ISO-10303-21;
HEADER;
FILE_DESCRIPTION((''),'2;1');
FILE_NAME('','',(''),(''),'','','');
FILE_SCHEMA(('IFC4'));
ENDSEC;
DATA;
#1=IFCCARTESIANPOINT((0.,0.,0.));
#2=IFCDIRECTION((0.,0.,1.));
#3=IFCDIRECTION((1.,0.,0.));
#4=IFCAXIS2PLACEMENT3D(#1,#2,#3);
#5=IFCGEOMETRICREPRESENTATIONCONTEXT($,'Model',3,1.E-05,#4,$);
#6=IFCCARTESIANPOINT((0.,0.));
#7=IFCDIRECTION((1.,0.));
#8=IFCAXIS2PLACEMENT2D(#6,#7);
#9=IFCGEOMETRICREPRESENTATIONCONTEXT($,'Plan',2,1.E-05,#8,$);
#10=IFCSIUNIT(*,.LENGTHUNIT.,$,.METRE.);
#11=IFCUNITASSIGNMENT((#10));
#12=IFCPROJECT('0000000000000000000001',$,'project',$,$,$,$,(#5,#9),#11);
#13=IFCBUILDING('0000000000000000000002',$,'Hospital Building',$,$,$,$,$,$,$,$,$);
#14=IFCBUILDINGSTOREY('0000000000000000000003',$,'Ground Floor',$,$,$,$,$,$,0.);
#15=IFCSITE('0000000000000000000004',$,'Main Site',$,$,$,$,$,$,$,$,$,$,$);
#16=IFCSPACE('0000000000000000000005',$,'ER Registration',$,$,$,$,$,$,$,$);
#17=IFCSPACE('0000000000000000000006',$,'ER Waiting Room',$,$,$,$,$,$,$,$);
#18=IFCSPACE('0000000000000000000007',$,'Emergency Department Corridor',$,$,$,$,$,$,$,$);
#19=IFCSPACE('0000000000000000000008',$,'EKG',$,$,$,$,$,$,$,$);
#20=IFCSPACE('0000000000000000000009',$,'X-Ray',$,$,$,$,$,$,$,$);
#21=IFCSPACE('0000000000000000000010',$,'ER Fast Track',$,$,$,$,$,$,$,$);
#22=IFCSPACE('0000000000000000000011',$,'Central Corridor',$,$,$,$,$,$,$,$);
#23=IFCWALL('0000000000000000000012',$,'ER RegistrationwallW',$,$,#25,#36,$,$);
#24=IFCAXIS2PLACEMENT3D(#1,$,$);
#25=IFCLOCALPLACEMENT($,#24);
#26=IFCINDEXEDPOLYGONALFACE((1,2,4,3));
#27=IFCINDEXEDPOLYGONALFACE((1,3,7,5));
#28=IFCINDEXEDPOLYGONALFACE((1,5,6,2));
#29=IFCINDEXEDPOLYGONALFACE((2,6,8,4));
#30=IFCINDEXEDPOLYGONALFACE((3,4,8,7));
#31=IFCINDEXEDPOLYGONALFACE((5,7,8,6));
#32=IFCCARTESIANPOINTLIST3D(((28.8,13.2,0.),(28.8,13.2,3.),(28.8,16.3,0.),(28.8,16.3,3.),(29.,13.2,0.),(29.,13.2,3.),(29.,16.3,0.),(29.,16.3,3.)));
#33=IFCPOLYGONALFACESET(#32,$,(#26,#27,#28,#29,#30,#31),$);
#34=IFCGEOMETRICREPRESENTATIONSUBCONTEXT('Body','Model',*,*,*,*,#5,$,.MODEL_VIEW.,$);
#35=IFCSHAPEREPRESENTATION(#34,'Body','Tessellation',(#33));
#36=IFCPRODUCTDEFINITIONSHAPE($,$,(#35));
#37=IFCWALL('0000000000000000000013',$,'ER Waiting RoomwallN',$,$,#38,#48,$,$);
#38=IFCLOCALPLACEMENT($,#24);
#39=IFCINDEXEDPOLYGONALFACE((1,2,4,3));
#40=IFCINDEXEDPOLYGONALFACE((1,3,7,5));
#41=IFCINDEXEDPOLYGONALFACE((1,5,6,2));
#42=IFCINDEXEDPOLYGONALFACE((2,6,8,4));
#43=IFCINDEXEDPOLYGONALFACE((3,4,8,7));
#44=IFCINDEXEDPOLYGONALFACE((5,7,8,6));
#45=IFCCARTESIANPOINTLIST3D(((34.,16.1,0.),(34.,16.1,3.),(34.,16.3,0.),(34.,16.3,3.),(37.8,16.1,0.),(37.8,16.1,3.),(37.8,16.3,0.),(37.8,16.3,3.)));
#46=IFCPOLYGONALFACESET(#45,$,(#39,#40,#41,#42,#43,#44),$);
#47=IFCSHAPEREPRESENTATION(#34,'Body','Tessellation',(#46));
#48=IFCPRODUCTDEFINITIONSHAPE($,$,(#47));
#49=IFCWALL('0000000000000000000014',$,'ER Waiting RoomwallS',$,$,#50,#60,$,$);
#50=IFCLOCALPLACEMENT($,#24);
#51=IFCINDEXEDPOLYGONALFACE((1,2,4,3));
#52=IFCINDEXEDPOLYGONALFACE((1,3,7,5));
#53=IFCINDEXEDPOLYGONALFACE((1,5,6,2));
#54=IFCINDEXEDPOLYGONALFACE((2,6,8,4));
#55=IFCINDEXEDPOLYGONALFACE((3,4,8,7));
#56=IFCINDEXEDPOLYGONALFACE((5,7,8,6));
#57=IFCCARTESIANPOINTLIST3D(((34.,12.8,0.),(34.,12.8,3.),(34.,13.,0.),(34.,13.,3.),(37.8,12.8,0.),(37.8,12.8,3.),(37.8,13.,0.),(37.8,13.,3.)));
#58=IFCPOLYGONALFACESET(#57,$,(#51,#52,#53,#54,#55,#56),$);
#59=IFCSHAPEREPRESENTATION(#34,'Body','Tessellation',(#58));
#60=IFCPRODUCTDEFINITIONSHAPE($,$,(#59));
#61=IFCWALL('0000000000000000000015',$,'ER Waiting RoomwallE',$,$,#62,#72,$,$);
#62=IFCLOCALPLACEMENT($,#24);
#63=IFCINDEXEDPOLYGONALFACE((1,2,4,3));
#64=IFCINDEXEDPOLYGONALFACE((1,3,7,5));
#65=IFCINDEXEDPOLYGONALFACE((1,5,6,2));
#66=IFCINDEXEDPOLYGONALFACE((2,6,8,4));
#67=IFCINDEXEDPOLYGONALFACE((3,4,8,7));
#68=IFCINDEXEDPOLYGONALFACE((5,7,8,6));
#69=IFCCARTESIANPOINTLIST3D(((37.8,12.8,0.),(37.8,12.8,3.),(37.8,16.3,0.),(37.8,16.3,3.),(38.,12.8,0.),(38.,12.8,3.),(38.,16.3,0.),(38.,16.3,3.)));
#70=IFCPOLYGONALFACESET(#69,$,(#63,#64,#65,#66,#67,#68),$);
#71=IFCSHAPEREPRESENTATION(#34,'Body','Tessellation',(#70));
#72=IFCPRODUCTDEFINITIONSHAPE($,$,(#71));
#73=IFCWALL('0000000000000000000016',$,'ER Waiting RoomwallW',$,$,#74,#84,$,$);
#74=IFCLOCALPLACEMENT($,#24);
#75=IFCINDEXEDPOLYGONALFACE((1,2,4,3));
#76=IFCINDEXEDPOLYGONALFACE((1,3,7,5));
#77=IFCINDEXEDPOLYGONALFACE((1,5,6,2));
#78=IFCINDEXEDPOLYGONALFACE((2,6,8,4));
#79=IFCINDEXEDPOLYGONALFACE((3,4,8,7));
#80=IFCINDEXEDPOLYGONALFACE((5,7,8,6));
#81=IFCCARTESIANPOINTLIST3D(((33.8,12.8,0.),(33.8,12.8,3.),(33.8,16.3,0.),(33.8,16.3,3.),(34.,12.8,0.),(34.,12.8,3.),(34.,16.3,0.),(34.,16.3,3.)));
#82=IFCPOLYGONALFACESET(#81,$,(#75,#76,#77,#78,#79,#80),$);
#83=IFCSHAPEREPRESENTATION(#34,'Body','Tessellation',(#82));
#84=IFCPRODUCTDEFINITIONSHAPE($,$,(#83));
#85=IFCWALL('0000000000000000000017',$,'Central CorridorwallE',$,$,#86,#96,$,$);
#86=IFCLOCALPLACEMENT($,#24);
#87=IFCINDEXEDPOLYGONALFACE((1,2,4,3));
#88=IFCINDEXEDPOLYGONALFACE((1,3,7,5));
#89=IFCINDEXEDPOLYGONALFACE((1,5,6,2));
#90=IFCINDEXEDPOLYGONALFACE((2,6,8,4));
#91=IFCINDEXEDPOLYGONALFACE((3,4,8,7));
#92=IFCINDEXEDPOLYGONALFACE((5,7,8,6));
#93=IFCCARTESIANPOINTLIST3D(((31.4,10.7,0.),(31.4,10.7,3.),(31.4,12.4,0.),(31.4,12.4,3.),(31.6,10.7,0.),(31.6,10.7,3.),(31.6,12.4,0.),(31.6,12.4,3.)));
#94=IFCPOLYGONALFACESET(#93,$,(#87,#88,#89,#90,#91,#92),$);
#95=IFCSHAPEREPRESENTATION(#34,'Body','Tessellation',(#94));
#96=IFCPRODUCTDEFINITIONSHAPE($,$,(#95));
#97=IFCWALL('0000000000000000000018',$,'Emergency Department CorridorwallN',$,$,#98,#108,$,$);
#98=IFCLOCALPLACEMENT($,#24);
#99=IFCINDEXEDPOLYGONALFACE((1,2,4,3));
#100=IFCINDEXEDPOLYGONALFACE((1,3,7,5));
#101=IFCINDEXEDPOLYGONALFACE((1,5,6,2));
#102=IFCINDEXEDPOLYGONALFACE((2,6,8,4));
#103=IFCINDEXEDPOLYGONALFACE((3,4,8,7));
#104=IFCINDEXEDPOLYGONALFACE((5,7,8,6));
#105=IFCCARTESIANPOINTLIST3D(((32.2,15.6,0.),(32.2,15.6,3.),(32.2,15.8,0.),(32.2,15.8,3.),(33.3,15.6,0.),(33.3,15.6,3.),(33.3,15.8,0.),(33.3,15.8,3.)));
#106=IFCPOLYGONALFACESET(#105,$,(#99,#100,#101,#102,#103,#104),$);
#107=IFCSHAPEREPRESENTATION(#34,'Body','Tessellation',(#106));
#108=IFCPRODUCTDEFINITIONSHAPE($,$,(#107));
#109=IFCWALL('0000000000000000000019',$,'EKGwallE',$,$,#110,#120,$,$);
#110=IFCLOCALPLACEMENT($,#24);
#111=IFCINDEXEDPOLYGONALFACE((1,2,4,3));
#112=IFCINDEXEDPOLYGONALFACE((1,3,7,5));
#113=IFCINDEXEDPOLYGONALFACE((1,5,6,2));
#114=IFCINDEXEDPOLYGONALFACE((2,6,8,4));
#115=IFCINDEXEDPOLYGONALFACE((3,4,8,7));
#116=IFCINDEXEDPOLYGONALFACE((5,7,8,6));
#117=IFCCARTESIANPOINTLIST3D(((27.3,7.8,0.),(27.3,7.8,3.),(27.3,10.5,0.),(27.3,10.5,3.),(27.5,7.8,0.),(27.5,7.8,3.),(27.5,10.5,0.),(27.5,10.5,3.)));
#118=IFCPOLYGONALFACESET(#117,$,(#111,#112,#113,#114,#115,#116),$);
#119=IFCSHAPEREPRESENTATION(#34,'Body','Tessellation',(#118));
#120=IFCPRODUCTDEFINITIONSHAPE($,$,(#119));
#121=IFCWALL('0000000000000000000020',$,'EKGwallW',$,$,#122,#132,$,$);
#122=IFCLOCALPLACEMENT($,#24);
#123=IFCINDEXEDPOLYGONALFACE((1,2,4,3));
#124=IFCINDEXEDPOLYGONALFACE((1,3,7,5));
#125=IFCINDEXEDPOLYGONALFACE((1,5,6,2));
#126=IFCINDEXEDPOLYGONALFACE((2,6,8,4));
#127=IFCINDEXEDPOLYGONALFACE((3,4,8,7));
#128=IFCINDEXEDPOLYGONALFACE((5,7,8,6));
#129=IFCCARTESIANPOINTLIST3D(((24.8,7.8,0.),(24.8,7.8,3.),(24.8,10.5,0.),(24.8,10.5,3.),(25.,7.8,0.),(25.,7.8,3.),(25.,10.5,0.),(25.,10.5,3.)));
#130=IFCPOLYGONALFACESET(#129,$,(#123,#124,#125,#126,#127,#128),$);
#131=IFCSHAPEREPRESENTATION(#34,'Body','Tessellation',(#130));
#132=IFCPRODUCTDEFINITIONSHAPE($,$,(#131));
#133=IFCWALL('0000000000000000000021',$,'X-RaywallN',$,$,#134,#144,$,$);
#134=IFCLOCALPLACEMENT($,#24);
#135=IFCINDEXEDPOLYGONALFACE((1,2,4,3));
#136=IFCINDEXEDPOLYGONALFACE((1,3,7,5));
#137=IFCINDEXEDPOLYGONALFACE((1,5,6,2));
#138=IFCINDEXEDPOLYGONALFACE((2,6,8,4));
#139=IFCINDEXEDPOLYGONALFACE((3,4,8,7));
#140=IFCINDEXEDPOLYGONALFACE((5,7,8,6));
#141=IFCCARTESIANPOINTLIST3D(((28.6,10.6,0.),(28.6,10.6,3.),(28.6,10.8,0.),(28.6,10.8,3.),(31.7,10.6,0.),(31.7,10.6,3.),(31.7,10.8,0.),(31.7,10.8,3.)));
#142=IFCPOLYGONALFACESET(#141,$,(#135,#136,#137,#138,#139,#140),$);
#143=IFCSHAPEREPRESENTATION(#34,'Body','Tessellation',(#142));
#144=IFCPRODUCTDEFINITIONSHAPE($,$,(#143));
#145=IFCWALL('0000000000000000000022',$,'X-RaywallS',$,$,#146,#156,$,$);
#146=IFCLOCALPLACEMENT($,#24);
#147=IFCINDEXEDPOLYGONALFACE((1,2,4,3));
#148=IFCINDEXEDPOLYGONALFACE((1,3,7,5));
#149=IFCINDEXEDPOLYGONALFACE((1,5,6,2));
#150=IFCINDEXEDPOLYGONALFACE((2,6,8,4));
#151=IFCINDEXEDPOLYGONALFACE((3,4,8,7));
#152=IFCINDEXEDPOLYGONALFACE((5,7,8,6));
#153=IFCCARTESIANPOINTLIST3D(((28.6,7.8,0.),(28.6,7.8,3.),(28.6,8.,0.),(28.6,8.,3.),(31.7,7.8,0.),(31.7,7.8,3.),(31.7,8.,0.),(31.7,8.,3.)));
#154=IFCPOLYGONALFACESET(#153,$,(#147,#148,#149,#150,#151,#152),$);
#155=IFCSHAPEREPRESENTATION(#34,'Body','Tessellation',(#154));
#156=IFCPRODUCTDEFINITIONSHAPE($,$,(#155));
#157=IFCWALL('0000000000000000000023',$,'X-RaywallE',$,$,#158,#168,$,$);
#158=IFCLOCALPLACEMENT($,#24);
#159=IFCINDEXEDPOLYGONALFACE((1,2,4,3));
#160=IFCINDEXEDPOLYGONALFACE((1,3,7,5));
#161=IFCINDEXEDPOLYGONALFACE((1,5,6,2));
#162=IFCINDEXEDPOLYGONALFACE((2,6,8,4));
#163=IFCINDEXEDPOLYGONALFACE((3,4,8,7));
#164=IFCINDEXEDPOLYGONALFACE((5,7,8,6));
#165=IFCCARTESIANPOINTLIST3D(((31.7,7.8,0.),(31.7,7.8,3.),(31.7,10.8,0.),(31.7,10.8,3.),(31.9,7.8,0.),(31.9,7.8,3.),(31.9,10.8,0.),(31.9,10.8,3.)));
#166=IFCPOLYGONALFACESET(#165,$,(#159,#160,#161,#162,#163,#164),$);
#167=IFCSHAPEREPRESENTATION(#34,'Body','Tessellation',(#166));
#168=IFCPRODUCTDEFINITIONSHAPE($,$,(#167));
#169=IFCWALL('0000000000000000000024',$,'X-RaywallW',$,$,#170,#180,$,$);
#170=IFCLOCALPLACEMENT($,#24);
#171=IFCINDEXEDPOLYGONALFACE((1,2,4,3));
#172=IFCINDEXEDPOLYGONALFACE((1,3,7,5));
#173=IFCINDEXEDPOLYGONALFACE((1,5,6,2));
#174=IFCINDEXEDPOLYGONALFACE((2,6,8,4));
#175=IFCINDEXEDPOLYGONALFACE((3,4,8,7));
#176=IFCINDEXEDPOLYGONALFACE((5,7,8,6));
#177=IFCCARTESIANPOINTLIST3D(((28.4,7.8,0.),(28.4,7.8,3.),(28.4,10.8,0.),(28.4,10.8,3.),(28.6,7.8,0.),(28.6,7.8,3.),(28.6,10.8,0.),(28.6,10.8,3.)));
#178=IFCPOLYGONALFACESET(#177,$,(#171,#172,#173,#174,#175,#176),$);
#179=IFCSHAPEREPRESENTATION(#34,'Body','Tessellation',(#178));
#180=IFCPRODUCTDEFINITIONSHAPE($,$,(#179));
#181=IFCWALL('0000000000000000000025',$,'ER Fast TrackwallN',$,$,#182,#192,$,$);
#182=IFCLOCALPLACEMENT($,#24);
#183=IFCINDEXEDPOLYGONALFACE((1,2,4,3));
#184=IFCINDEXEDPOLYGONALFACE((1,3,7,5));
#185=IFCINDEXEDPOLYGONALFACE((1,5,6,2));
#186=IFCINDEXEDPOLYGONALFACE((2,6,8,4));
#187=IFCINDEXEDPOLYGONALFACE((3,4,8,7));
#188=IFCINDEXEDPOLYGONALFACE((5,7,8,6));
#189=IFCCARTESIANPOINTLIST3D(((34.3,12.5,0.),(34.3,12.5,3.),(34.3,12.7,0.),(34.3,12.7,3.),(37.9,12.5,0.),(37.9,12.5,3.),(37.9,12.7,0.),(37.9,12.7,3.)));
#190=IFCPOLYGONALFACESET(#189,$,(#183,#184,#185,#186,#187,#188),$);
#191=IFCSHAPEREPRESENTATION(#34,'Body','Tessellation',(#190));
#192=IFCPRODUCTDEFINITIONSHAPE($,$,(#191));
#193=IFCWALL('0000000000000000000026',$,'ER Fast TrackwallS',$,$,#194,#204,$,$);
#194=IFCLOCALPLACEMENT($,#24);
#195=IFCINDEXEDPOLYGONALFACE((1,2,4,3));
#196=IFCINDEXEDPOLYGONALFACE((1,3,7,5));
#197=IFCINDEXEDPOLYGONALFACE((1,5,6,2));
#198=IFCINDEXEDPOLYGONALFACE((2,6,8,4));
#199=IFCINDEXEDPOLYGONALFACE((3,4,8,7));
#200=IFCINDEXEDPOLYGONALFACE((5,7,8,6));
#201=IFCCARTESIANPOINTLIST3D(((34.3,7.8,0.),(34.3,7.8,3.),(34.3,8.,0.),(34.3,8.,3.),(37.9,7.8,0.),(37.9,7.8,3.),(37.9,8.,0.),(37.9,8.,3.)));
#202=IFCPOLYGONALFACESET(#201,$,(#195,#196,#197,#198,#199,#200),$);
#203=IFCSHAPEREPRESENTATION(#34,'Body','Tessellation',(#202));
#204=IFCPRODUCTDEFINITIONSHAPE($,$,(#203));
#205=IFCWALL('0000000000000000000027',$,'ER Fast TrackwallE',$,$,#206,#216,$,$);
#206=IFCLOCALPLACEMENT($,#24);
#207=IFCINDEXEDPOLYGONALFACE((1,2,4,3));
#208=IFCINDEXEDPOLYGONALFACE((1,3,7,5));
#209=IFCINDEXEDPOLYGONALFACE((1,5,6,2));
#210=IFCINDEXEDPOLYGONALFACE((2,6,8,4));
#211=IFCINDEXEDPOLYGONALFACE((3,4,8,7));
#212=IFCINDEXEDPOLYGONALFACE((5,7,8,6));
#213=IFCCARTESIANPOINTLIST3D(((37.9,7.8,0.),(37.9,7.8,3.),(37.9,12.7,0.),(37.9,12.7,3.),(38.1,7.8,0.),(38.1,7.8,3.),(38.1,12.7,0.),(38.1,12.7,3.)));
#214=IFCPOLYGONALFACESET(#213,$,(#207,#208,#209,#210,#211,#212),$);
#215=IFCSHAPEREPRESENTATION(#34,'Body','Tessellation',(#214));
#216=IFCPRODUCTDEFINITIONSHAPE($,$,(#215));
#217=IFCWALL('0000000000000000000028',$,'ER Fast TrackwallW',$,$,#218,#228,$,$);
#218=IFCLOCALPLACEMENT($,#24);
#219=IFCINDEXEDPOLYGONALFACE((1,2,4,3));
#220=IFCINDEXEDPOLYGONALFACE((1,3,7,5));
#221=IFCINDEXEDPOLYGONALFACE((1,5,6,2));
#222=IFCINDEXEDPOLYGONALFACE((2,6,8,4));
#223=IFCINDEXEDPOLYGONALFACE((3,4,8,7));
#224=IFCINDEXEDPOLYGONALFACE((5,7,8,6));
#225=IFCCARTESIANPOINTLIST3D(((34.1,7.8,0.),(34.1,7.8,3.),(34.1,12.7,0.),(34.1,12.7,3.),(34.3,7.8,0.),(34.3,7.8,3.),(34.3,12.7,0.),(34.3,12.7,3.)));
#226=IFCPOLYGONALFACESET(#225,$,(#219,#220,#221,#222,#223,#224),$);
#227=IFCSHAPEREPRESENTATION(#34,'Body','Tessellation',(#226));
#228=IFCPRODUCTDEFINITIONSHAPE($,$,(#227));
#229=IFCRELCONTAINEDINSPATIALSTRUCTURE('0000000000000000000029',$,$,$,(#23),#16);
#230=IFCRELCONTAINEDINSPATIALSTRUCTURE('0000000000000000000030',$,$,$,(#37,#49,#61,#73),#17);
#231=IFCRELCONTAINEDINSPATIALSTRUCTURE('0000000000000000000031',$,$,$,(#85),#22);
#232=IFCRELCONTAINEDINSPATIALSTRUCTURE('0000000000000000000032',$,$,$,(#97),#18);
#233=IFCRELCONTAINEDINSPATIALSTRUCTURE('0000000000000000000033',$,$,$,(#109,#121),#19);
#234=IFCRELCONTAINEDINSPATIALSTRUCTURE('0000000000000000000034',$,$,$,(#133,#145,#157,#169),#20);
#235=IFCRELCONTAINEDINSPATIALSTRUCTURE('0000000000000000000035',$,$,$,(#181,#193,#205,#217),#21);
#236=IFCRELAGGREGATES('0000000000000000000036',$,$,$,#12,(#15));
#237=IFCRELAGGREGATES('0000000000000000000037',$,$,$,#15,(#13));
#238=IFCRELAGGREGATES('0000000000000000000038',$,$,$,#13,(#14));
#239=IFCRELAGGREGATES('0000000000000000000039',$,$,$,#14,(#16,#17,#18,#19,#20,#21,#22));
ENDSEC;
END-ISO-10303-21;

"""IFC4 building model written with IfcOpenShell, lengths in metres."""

from ifc_helpers import new_model, si_unit, frame, origin_with_axes, origin_2d_with_axis, place, context, subcontext, project, spatial, indexed_curve, outline, extrude, element, save


model = new_model("IFC4")

# Units and contexts
model_context = context("Model", 3, precision=1e-05, world=origin_with_axes())
plan_context = context("Plan", 2, precision=1e-05, world=origin_2d_with_axis())
body_context = subcontext(model_context, "Body", "Model", "MODEL_VIEW")
ifc_project = project(units=[si_unit("LENGTHUNIT", "METRE")], contexts=[model_context, plan_context])

# Site, building, storey
site = spatial("IfcSite", under=ifc_project, Name="Main Site")
building = spatial("IfcBuilding", under=site, Name="Hospital Building")
storey = spatial("IfcBuildingStorey", under=building, Name="Ground Floor", Elevation=0.0)

# Shared definitions
space_1 = spatial("IfcSpace", under=storey, Name="ER Registration")

# Shared definitions
space_2 = spatial("IfcSpace", under=storey, Name="ER Waiting Room")

# Shared definitions
space_3 = spatial("IfcSpace", under=storey, Name="Emergency Department Corridor")

# Shared definitions
space_4 = spatial("IfcSpace", under=storey, Name="EKG")

# Shared definitions
space_5 = spatial("IfcSpace", under=storey, Name="X-Ray")

# Shared definitions
space_6 = spatial("IfcSpace", under=storey, Name="ER Fast Track")

# Walls
for number, where, z_axis, x_axis, name in (
    (1, (29.0, 13.2, 0.0), (0.0, 0.0, 1.0), (0.0, 1.0, 0.0), "ER RegistrationwallW"),
):
    element("IfcWall", number, at=place(None, frame(where, z_axis=z_axis, x_axis=x_axis)), inside=space_1, Name=name, context=body_context, shape_type="SweptSolid", body=[
        extrude(outline(indexed_curve([(0.0, 0.0), (0.0, 0.2), (3.1, 0.2), (3.1, 0.0), (0.0, 0.0)], self_intersect=False)), origin_with_axes(), (0.0, 0.0, 1.0), 3.0),
    ])
for number, where, z_axis, x_axis, name in (
    (2, (34.0, 16.1, 0.0), (0.0, 0.0, 1.0), (1.0, 0.0, 0.0), "ER Waiting RoomwallN"),
    (3, (34.0, 12.8, 0.0), (0.0, 0.0, 1.0), (1.0, 0.0, 0.0), "ER Waiting RoomwallS"),
):
    element("IfcWall", number, at=place(None, frame(where, z_axis=z_axis, x_axis=x_axis)), inside=space_2, Name=name, context=body_context, shape_type="SweptSolid", body=[
        extrude(outline(indexed_curve([(0.0, 0.0), (0.0, 0.2), (3.8, 0.2), (3.8, 0.0), (0.0, 0.0)], self_intersect=False)), origin_with_axes(), (0.0, 0.0, 1.0), 3.0),
    ])
for number, where, z_axis, x_axis, name in (
    (4, (38.0, 12.8, 0.0), (0.0, 0.0, 1.0), (0.0, 1.0, 0.0), "ER Waiting RoomwallE"),
    (5, (34.0, 12.8, 0.0), (0.0, 0.0, 1.0), (0.0, 1.0, 0.0), "ER Waiting RoomwallW"),
):
    element("IfcWall", number, at=place(None, frame(where, z_axis=z_axis, x_axis=x_axis)), inside=space_2, Name=name, context=body_context, shape_type="SweptSolid", body=[
        extrude(outline(indexed_curve([(0.0, 0.0), (0.0, 0.2), (3.5, 0.2), (3.5, 0.0), (0.0, 0.0)], self_intersect=False)), origin_with_axes(), (0.0, 0.0, 1.0), 3.0),
    ])

# Shared definitions
space_7 = spatial("IfcSpace", under=storey, Name="Central Corridor")

# Walls
wall_1_placement = place(None, frame((31.6, 10.7, 0.0), z_axis=(0.0, 0.0, 1.0), x_axis=(0.0, 1.0, 0.0)))
element("IfcWall", 6, at=wall_1_placement, inside=space_7, Name="Central CorridorwallE", context=body_context, shape_type="SweptSolid", body=[
    extrude(outline(indexed_curve([(0.0, 0.0), (0.0, 0.2), (1.7, 0.2), (1.7, 0.0), (0.0, 0.0)], self_intersect=False)), origin_with_axes(), (0.0, 0.0, 1.0), 3.0),
])
wall_2_placement = place(None, frame((32.2, 15.6, 0.0), z_axis=(0.0, 0.0, 1.0), x_axis=(1.0, 0.0, 0.0)))
element("IfcWall", 7, at=wall_2_placement, inside=space_3, Name="Emergency Department CorridorwallN", context=body_context, shape_type="SweptSolid", body=[
    extrude(outline(indexed_curve([(0.0, 0.0), (0.0, 0.2), (1.1, 0.2), (1.1, 0.0), (0.0, 0.0)], self_intersect=False)), origin_with_axes(), (0.0, 0.0, 1.0), 3.0),
])
for number, where, z_axis, x_axis, name in (
    (8, (27.5, 7.8, 0.0), (0.0, 0.0, 1.0), (0.0, 1.0, 0.0), "EKGwallE"),
    (9, (25.0, 7.8, 0.0), (0.0, 0.0, 1.0), (0.0, 1.0, 0.0), "EKGwallW"),
):
    element("IfcWall", number, at=place(None, frame(where, z_axis=z_axis, x_axis=x_axis)), inside=space_4, Name=name, context=body_context, shape_type="SweptSolid", body=[
        extrude(outline(indexed_curve([(0.0, 0.0), (0.0, 0.2), (2.7, 0.2), (2.7, 0.0), (0.0, 0.0)], self_intersect=False)), origin_with_axes(), (0.0, 0.0, 1.0), 3.0),
    ])
for number, where, z_axis, x_axis, name in (
    (10, (28.6, 10.6, 0.0), (0.0, 0.0, 1.0), (1.0, 0.0, 0.0), "X-RaywallN"),
    (11, (28.6, 7.8, 0.0), (0.0, 0.0, 1.0), (1.0, 0.0, 0.0), "X-RaywallS"),
):
    element("IfcWall", number, at=place(None, frame(where, z_axis=z_axis, x_axis=x_axis)), inside=space_5, Name=name, context=body_context, shape_type="SweptSolid", body=[
        extrude(outline(indexed_curve([(0.0, 0.0), (0.0, 0.2), (3.1, 0.2), (3.1, 0.0), (0.0, 0.0)], self_intersect=False)), origin_with_axes(), (0.0, 0.0, 1.0), 3.0),
    ])
for number, where, z_axis, x_axis, name in (
    (12, (31.9, 7.8, 0.0), (0.0, 0.0, 1.0), (0.0, 1.0, 0.0), "X-RaywallE"),
    (13, (28.6, 7.8, 0.0), (0.0, 0.0, 1.0), (0.0, 1.0, 0.0), "X-RaywallW"),
):
    element("IfcWall", number, at=place(None, frame(where, z_axis=z_axis, x_axis=x_axis)), inside=space_5, Name=name, context=body_context, shape_type="SweptSolid", body=[
        extrude(outline(indexed_curve([(0.0, 0.0), (0.0, 0.2), (3.0, 0.2), (3.0, 0.0), (0.0, 0.0)], self_intersect=False)), origin_with_axes(), (0.0, 0.0, 1.0), 3.0),
    ])
for number, where, z_axis, x_axis, name in (
    (14, (34.3, 12.5, 0.0), (0.0, 0.0, 1.0), (1.0, 0.0, 0.0), "ER Fast TrackwallN"),
    (15, (34.3, 7.8, 0.0), (0.0, 0.0, 1.0), (1.0, 0.0, 0.0), "ER Fast TrackwallS"),
):
    element("IfcWall", number, at=place(None, frame(where, z_axis=z_axis, x_axis=x_axis)), inside=space_6, Name=name, context=body_context, shape_type="SweptSolid", body=[
        extrude(outline(indexed_curve([(0.0, 0.0), (0.0, 0.2), (3.6, 0.2), (3.6, 0.0), (0.0, 0.0)], self_intersect=False)), origin_with_axes(), (0.0, 0.0, 1.0), 3.0),
    ])
for number, where, z_axis, x_axis, name in (
    (16, (38.1, 7.8, 0.0), (0.0, 0.0, 1.0), (0.0, 1.0, 0.0), "ER Fast TrackwallE"),
    (17, (34.3, 7.8, 0.0), (0.0, 0.0, 1.0), (0.0, 1.0, 0.0), "ER Fast TrackwallW"),
):
    element("IfcWall", number, at=place(None, frame(where, z_axis=z_axis, x_axis=x_axis)), inside=space_6, Name=name, context=body_context, shape_type="SweptSolid", body=[
        extrude(outline(indexed_curve([(0.0, 0.0), (0.0, 0.2), (4.9, 0.2), (4.9, 0.0), (0.0, 0.0)], self_intersect=False)), origin_with_axes(), (0.0, 0.0, 1.0), 3.0),
    ])

save(model, "model.ifc")
